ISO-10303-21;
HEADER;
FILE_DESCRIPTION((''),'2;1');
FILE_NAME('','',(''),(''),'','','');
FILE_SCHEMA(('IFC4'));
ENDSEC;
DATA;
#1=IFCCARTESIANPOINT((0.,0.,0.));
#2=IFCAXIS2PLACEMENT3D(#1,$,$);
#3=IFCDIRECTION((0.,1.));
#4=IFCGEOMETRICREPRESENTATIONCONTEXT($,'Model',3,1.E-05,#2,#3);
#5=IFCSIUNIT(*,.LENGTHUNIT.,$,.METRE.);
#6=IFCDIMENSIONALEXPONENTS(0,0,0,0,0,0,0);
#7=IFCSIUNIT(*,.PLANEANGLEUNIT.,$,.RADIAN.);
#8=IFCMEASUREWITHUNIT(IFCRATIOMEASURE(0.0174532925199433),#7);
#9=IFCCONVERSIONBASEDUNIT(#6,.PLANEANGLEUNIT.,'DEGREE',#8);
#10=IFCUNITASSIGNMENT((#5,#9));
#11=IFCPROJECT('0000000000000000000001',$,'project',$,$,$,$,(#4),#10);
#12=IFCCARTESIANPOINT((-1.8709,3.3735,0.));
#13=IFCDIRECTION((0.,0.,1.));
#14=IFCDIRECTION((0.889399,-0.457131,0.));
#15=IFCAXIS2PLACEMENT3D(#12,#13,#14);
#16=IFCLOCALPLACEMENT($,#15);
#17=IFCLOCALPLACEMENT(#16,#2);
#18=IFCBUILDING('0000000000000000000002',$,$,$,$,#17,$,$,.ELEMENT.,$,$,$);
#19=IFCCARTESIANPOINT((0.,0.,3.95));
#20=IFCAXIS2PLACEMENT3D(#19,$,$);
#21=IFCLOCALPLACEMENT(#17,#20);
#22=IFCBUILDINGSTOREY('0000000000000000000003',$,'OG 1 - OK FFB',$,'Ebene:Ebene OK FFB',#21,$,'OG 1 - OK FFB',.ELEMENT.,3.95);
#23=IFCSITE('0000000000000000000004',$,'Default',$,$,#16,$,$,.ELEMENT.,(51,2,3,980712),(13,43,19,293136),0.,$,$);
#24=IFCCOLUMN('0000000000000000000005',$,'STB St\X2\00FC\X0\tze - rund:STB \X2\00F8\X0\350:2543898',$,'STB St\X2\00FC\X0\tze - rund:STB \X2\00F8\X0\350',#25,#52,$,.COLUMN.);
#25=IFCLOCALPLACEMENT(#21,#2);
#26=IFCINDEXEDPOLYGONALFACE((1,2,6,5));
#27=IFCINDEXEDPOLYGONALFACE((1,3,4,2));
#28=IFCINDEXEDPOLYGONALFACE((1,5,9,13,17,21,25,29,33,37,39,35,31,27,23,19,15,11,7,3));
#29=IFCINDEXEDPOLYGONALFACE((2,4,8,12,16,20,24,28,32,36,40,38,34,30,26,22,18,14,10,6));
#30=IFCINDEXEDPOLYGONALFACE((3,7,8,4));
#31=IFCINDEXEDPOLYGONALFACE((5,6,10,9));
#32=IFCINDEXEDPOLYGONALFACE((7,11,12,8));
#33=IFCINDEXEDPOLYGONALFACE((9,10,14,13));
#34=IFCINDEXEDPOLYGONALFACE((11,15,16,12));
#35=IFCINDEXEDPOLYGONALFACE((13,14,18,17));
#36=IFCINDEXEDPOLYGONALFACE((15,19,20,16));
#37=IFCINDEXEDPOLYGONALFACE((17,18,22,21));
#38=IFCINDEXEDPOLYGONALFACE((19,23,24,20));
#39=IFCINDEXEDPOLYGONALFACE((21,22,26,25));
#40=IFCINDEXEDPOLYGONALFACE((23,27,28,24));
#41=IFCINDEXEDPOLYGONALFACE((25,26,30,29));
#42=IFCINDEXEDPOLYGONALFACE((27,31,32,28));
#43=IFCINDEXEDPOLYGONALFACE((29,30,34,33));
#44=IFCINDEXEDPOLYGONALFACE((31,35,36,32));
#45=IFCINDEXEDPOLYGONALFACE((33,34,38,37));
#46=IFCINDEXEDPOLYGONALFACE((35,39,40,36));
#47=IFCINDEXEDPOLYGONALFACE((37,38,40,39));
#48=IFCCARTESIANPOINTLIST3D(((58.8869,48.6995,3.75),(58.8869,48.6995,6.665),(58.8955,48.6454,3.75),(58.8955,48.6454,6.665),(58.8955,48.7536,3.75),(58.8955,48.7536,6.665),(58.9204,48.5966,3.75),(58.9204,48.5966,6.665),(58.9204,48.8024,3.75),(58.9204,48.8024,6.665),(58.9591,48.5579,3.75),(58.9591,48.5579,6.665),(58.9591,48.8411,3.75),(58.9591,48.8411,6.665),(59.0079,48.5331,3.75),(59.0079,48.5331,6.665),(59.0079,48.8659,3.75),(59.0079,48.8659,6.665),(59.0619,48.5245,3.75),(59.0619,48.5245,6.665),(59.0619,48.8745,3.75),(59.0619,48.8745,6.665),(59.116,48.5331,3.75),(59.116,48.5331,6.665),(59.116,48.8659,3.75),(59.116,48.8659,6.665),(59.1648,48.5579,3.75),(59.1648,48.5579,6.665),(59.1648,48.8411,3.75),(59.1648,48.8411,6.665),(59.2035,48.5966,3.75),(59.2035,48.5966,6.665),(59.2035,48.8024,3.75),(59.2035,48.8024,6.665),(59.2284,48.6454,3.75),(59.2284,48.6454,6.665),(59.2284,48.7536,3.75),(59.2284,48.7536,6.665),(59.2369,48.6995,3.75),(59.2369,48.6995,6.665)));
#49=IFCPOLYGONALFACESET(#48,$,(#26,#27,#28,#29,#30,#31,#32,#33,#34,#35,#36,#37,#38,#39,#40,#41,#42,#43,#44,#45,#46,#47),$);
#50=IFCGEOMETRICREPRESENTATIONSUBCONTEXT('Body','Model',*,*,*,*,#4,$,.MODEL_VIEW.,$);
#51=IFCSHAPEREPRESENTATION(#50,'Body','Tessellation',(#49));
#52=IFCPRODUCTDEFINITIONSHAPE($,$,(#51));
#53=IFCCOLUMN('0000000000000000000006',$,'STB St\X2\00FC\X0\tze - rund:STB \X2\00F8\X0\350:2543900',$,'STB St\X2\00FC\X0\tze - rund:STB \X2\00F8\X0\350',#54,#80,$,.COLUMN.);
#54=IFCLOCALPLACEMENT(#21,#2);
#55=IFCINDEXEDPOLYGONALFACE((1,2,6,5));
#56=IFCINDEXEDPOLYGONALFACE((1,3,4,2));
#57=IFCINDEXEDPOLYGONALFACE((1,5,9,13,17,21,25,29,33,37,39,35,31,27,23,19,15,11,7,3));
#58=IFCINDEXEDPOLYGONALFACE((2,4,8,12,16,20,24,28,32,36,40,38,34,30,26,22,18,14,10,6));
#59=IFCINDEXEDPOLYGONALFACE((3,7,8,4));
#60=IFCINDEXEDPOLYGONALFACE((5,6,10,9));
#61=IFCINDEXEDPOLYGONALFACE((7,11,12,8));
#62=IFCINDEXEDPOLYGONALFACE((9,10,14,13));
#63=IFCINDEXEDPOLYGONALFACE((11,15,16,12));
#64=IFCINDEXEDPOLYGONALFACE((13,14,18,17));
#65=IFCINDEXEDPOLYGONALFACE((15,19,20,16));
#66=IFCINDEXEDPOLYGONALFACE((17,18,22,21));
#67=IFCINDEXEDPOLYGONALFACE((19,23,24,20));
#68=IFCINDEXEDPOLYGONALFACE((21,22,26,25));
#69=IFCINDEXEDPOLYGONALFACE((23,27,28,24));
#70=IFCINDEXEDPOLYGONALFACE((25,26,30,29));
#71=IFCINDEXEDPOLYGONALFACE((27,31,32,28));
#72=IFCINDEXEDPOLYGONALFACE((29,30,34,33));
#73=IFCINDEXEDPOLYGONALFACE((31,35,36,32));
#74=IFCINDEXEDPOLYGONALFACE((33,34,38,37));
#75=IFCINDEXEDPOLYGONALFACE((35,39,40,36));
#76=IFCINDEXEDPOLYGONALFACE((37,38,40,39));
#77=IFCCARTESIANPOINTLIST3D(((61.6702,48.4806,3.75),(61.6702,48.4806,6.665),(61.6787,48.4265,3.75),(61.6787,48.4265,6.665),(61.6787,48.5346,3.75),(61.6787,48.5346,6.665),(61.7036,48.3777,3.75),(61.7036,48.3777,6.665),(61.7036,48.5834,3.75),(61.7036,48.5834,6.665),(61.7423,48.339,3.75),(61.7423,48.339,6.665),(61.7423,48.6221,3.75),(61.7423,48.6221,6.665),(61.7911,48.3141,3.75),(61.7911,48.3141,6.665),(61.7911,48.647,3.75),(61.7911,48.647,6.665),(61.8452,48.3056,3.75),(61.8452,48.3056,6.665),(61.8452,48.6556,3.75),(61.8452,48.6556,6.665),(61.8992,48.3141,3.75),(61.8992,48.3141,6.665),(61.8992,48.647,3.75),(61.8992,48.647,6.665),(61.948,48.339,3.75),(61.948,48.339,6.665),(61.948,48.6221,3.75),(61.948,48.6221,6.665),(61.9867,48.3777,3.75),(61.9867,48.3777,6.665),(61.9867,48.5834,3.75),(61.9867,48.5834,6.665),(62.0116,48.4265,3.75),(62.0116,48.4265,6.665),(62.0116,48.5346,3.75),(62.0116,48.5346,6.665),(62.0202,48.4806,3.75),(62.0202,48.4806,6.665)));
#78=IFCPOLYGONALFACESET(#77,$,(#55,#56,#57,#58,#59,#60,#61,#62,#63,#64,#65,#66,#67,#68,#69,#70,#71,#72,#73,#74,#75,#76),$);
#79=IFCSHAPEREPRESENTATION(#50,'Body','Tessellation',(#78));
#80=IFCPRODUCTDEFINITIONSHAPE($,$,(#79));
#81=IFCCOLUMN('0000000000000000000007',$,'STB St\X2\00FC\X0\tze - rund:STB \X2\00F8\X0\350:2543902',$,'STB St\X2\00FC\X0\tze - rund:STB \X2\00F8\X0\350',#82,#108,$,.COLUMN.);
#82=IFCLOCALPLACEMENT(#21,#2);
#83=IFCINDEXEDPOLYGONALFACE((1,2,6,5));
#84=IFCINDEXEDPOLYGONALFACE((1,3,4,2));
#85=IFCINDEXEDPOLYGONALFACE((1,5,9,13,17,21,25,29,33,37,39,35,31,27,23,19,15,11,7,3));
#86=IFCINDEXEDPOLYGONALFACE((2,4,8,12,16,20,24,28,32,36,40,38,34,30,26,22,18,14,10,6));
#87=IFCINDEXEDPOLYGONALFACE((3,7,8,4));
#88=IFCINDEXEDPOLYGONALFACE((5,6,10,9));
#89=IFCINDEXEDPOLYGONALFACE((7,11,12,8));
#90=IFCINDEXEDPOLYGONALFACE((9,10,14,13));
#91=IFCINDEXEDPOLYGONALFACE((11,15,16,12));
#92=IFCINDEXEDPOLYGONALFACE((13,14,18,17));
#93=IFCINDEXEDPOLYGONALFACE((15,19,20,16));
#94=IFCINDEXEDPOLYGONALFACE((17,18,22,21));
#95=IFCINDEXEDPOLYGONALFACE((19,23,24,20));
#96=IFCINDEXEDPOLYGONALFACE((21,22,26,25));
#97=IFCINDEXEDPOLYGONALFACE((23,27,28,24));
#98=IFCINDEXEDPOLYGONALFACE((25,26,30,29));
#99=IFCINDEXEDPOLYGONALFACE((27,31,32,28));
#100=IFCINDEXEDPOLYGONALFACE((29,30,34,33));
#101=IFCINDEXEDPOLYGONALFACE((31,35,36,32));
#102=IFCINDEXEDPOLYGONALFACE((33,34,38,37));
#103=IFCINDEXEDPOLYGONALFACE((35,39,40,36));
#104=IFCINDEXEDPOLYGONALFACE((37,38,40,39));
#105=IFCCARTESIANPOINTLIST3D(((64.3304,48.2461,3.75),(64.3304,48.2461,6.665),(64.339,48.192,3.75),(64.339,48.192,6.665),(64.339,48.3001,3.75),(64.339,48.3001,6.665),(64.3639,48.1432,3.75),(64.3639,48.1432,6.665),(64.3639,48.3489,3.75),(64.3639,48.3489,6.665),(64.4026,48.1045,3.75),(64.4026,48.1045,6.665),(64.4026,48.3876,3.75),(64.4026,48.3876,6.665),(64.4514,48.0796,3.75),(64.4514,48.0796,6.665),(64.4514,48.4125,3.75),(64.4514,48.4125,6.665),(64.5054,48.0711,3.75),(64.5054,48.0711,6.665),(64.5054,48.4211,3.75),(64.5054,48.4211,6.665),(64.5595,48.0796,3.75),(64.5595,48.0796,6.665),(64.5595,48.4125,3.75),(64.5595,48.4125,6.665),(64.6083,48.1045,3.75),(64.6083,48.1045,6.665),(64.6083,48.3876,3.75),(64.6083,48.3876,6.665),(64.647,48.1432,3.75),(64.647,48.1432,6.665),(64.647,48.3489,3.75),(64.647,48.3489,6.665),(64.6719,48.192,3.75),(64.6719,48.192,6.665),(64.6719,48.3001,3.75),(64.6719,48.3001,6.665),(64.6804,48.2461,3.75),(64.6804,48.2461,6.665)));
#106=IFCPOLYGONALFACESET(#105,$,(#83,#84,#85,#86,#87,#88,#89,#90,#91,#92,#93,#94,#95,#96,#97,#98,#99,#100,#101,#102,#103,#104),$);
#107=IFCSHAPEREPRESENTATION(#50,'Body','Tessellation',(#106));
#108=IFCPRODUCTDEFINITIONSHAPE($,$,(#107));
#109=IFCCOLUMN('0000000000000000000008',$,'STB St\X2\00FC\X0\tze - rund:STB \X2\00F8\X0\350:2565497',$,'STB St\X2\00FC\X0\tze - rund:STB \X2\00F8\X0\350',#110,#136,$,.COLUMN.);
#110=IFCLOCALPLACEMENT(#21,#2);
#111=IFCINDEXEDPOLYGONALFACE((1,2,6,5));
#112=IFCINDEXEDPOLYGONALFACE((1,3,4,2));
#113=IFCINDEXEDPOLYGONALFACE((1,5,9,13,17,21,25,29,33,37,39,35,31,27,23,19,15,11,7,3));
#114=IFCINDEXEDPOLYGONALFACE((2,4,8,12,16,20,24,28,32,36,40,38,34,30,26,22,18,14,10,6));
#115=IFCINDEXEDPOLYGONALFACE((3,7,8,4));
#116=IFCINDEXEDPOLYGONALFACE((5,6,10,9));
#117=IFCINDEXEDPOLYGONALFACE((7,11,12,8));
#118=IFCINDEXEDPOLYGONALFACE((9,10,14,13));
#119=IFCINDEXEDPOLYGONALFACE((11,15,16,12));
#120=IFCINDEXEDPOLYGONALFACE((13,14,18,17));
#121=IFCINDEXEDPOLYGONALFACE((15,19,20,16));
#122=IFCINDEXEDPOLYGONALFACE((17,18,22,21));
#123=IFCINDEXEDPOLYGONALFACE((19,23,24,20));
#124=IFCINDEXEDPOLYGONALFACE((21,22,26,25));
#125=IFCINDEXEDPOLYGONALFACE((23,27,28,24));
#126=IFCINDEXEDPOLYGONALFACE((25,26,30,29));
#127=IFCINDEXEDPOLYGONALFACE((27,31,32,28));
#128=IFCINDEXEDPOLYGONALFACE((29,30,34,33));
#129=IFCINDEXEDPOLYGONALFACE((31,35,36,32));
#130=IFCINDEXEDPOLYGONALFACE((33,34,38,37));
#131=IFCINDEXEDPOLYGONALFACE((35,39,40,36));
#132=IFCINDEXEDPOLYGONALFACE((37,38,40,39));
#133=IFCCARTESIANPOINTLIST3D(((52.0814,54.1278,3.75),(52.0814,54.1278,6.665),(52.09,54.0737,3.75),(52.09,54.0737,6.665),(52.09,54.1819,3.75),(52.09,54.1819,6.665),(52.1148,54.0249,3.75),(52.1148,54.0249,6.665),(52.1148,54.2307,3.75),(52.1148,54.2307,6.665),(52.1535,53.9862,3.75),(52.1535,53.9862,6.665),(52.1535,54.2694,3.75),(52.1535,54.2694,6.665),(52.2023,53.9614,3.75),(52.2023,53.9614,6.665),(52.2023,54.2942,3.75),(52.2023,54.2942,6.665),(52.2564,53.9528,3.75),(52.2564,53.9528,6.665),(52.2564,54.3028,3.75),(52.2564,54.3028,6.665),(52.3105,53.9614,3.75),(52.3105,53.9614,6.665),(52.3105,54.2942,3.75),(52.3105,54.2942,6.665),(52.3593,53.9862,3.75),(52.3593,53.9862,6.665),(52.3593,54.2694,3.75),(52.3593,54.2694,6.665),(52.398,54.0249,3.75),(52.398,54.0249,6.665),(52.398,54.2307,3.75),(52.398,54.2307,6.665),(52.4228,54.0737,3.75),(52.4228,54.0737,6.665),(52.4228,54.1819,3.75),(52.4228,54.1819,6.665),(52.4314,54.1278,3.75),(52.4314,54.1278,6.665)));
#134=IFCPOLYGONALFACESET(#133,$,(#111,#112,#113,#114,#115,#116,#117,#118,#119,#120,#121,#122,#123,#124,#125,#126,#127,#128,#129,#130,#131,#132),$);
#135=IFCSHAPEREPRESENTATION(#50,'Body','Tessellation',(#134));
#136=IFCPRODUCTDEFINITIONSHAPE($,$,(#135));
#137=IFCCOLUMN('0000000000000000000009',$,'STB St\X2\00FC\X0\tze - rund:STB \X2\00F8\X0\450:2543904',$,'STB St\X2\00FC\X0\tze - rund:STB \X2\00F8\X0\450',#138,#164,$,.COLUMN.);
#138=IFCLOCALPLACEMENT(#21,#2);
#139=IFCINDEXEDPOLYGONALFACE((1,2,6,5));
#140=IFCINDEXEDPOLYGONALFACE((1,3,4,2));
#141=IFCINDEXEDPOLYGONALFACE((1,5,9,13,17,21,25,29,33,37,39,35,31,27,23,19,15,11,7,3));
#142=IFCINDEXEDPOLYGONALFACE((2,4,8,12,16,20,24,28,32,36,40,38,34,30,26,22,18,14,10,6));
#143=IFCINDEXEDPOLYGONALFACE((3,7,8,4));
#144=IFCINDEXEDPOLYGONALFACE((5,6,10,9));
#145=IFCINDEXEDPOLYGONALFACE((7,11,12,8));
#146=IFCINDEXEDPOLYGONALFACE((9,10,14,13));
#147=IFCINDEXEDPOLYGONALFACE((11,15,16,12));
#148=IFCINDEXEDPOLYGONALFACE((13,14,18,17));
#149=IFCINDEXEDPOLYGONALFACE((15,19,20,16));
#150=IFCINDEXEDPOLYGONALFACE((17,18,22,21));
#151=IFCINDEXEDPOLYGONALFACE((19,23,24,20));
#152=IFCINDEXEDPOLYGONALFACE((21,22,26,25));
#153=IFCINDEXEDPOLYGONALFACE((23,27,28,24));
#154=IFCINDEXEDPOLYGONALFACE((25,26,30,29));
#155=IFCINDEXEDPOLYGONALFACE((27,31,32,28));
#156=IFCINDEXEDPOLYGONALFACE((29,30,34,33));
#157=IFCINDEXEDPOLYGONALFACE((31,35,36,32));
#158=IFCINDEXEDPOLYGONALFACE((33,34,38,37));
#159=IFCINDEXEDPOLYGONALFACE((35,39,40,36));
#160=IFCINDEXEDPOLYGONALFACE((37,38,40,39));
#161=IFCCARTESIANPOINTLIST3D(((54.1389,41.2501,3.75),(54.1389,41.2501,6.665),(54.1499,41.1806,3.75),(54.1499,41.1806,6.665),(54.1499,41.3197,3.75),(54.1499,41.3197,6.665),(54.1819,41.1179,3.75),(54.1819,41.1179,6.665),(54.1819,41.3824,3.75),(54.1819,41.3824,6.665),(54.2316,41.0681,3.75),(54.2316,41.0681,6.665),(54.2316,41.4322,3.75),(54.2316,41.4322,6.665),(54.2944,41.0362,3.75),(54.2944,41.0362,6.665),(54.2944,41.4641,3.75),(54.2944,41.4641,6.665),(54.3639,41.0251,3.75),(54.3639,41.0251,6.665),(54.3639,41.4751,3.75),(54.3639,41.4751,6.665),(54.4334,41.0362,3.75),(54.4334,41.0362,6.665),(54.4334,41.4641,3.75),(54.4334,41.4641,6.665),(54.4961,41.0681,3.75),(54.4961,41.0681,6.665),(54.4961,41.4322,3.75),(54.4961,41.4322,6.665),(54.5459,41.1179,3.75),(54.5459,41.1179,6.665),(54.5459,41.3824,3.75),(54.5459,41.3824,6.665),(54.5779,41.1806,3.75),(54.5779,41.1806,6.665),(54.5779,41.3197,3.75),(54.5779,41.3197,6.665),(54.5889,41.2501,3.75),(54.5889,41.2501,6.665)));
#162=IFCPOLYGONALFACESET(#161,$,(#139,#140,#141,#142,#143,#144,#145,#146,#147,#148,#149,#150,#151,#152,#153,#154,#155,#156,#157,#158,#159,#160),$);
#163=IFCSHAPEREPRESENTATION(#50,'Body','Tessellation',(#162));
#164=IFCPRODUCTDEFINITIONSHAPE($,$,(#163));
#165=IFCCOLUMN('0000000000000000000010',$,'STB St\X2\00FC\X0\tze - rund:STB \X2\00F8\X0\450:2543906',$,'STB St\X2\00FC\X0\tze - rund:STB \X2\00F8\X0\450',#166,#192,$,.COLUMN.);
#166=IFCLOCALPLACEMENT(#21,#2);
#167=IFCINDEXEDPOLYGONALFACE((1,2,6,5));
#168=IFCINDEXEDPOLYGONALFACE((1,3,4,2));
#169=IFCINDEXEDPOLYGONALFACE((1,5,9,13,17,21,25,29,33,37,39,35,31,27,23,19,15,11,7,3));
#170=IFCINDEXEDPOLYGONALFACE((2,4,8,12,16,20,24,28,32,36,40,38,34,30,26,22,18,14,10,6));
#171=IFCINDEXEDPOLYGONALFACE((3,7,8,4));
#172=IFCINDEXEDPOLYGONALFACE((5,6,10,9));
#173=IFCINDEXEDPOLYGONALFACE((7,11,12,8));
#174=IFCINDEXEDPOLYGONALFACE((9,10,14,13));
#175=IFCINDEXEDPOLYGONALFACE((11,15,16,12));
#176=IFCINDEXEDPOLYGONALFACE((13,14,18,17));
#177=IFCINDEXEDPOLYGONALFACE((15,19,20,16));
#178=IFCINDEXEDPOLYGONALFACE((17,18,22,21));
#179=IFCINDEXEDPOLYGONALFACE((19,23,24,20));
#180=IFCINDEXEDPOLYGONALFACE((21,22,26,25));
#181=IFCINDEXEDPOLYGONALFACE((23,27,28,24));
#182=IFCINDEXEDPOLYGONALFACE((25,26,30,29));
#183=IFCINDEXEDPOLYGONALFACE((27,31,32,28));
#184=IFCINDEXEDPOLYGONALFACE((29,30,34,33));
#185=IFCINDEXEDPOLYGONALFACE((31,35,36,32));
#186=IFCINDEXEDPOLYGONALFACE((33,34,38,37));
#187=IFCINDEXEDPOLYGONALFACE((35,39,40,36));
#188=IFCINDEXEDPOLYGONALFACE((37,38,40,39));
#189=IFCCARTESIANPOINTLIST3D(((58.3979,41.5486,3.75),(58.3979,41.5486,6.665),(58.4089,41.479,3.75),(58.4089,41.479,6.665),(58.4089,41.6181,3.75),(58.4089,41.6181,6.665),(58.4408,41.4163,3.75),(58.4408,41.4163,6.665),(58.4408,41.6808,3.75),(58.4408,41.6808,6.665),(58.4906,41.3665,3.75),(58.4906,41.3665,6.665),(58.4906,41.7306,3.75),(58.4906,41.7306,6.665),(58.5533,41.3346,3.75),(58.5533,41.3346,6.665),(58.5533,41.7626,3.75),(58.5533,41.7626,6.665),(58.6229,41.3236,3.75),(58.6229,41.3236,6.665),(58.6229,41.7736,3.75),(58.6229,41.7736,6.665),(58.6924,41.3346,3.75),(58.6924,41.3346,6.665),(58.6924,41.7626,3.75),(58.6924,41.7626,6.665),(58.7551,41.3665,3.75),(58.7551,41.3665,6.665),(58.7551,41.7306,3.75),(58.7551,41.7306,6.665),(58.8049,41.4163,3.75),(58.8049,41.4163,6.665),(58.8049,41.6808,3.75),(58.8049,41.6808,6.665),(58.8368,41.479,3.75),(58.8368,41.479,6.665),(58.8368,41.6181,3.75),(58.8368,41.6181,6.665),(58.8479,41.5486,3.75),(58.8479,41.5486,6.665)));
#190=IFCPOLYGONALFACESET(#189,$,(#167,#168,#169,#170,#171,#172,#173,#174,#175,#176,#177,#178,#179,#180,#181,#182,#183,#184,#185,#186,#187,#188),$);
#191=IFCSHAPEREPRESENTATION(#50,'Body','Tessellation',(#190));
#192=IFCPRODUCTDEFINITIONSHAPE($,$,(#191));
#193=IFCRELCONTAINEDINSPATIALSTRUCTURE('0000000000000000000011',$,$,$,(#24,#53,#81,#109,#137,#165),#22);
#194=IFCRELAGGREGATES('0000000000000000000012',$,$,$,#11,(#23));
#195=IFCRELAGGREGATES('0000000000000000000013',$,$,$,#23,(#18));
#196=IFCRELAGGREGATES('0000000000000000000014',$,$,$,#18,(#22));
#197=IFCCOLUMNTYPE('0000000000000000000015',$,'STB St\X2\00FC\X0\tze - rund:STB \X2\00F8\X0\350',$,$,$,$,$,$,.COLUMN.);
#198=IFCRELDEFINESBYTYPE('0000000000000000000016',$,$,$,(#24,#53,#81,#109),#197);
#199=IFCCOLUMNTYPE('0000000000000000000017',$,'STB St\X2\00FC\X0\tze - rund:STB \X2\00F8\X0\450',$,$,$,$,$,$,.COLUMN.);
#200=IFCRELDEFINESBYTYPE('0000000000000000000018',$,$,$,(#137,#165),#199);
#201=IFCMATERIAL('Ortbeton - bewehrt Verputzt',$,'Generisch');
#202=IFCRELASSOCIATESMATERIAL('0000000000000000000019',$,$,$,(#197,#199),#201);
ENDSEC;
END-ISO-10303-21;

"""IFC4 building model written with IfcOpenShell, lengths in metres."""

from ifc_helpers import new_model, entity, si_unit, converted_unit, direction, frame, origin, place, context, subcontext, project, spatial, indexed_curve, outline, extrude, source, transform, mapped, material, type_object, type_shapes, element, save


model = new_model("IFC4")

# Units and contexts
model_context = context("Model", 3, precision=1e-05, world=origin(), true_north=direction((0.0, 1.0)))
body_context = subcontext(model_context, "Body", "Model", "MODEL_VIEW")
ifc_project = project(units=[si_unit("LENGTHUNIT", "METRE"), converted_unit("PLANEANGLEUNIT", "DEGREE", entity("IfcRatioMeasure", 0.0174532925199433), si_unit("PLANEANGLEUNIT", "RADIAN"), dimensions=[0, 0, 0, 0, 0, 0, 0])], contexts=[model_context])

# Site, building, storey
site_placement = place(None, frame((-1.8709, 3.3735, 0.0), z_axis=(0.0, 0.0, 1.0), x_axis=(0.889399, -0.457131, 0.0)))
site = spatial("IfcSite", under=ifc_project, at=site_placement, Name="Default", CompositionType="ELEMENT", RefLatitude=(51, 2, 3, 980712), RefLongitude=(13, 43, 19, 293136), RefElevation=0.0)
building_placement = place(site_placement, origin())
building = spatial("IfcBuilding", under=site, at=building_placement, CompositionType="ELEMENT")
storey_placement = place(building_placement, frame((0.0, 0.0, 3.95)))
storey = spatial("IfcBuildingStorey", under=building, at=storey_placement, Name="OG 1 - OK FFB", ObjectType="Ebene:Ebene OK FFB", LongName="OG 1 - OK FFB", CompositionType="ELEMENT", Elevation=3.95)

# Columns
ifc_material_1 = material(Name="Ortbeton - bewehrt Verputzt", Category="Generisch")
column_type_1 = type_object("IfcColumnType", Name="STB Stütze - rund:STB ø350", PredefinedType="COLUMN", material=ifc_material_1)
shared_shape_1 = source(origin(), body_context, "Body", "SweptSolid", [
    extrude(outline(indexed_curve([(0.175, 0.0), (0.1664, 0.0541), (0.1416, 0.1029), (0.1029, 0.1416), (0.0541, 0.1664), (0.0, 0.175), (-0.0541, 0.1664), (-0.1029, 0.1416), (-0.1416, 0.1029), (-0.1664, 0.0541), (-0.175, 0.0), (-0.1664, -0.0541), (-0.1416, -0.1029), (-0.1029, -0.1416), (-0.0541, -0.1664), (0.0, -0.175), (0.0541, -0.1664), (0.1029, -0.1416), (0.1416, -0.1029), (0.1664, -0.0541), (0.175, 0.0)], self_intersect=False)), frame((0.0, 0.0, 7.7), z_axis=(0.0, 0.0, 1.0), x_axis=(-1.0, 0.0, 0.0)), (0.0, 0.0, 1.0), 2.915),
])
type_shapes(column_type_1, [shared_shape_1])
for number, where, name in (
    (1, (59.0619, 48.6995, -3.95), "STB Stütze - rund:STB ø350:2543898"),
    (2, (61.8452, 48.4806, -3.95), "STB Stütze - rund:STB ø350:2543900"),
    (3, (64.5054, 48.2461, -3.95), "STB Stütze - rund:STB ø350:2543902"),
    (4, (52.2564, 54.1278, -3.95), "STB Stütze - rund:STB ø350:2565497"),
):
    element("IfcColumn", number, at=place(storey_placement, frame(where)), inside=storey, type_object=column_type_1, Name=name, ObjectType="STB Stütze - rund:STB ø350", PredefinedType="COLUMN", context=body_context, shape_type="MappedRepresentation", body=[
        mapped(shared_shape_1, transform((0.0, 0.0, 0.0), scale=1.0)),
    ])
column_type_2 = type_object("IfcColumnType", Name="STB Stütze - rund:STB ø450", PredefinedType="COLUMN", material=ifc_material_1)
shared_shape_2 = source(origin(), body_context, "Body", "SweptSolid", [
    extrude(outline(indexed_curve([(0.225, 0.0), (0.214, 0.0695), (0.182, 0.1323), (0.1323, 0.182), (0.0695, 0.214), (0.0, 0.225), (-0.0695, 0.214), (-0.1323, 0.182), (-0.182, 0.1323), (-0.214, 0.0695), (-0.225, 0.0), (-0.214, -0.0695), (-0.182, -0.1323), (-0.1323, -0.182), (-0.0695, -0.214), (0.0, -0.225), (0.0695, -0.214), (0.1323, -0.182), (0.182, -0.1323), (0.214, -0.0695), (0.225, 0.0)], self_intersect=False)), frame((0.0, 0.0, 7.7), z_axis=(0.0, 0.0, 1.0), x_axis=(-1.0, 0.0, 0.0)), (0.0, 0.0, 1.0), 2.915),
])
type_shapes(column_type_2, [shared_shape_2])
for number, where, name in (
    (5, (54.3639, 41.2501, -3.95), "STB Stütze - rund:STB ø450:2543904"),
    (6, (58.6229, 41.5486, -3.95), "STB Stütze - rund:STB ø450:2543906"),
):
    element("IfcColumn", number, at=place(storey_placement, frame(where)), inside=storey, type_object=column_type_2, Name=name, ObjectType="STB Stütze - rund:STB ø450", PredefinedType="COLUMN", context=body_context, shape_type="MappedRepresentation", body=[
        mapped(shared_shape_2, transform((0.0, 0.0, 0.0), scale=1.0)),
    ])

save(model, "model.ifc")
